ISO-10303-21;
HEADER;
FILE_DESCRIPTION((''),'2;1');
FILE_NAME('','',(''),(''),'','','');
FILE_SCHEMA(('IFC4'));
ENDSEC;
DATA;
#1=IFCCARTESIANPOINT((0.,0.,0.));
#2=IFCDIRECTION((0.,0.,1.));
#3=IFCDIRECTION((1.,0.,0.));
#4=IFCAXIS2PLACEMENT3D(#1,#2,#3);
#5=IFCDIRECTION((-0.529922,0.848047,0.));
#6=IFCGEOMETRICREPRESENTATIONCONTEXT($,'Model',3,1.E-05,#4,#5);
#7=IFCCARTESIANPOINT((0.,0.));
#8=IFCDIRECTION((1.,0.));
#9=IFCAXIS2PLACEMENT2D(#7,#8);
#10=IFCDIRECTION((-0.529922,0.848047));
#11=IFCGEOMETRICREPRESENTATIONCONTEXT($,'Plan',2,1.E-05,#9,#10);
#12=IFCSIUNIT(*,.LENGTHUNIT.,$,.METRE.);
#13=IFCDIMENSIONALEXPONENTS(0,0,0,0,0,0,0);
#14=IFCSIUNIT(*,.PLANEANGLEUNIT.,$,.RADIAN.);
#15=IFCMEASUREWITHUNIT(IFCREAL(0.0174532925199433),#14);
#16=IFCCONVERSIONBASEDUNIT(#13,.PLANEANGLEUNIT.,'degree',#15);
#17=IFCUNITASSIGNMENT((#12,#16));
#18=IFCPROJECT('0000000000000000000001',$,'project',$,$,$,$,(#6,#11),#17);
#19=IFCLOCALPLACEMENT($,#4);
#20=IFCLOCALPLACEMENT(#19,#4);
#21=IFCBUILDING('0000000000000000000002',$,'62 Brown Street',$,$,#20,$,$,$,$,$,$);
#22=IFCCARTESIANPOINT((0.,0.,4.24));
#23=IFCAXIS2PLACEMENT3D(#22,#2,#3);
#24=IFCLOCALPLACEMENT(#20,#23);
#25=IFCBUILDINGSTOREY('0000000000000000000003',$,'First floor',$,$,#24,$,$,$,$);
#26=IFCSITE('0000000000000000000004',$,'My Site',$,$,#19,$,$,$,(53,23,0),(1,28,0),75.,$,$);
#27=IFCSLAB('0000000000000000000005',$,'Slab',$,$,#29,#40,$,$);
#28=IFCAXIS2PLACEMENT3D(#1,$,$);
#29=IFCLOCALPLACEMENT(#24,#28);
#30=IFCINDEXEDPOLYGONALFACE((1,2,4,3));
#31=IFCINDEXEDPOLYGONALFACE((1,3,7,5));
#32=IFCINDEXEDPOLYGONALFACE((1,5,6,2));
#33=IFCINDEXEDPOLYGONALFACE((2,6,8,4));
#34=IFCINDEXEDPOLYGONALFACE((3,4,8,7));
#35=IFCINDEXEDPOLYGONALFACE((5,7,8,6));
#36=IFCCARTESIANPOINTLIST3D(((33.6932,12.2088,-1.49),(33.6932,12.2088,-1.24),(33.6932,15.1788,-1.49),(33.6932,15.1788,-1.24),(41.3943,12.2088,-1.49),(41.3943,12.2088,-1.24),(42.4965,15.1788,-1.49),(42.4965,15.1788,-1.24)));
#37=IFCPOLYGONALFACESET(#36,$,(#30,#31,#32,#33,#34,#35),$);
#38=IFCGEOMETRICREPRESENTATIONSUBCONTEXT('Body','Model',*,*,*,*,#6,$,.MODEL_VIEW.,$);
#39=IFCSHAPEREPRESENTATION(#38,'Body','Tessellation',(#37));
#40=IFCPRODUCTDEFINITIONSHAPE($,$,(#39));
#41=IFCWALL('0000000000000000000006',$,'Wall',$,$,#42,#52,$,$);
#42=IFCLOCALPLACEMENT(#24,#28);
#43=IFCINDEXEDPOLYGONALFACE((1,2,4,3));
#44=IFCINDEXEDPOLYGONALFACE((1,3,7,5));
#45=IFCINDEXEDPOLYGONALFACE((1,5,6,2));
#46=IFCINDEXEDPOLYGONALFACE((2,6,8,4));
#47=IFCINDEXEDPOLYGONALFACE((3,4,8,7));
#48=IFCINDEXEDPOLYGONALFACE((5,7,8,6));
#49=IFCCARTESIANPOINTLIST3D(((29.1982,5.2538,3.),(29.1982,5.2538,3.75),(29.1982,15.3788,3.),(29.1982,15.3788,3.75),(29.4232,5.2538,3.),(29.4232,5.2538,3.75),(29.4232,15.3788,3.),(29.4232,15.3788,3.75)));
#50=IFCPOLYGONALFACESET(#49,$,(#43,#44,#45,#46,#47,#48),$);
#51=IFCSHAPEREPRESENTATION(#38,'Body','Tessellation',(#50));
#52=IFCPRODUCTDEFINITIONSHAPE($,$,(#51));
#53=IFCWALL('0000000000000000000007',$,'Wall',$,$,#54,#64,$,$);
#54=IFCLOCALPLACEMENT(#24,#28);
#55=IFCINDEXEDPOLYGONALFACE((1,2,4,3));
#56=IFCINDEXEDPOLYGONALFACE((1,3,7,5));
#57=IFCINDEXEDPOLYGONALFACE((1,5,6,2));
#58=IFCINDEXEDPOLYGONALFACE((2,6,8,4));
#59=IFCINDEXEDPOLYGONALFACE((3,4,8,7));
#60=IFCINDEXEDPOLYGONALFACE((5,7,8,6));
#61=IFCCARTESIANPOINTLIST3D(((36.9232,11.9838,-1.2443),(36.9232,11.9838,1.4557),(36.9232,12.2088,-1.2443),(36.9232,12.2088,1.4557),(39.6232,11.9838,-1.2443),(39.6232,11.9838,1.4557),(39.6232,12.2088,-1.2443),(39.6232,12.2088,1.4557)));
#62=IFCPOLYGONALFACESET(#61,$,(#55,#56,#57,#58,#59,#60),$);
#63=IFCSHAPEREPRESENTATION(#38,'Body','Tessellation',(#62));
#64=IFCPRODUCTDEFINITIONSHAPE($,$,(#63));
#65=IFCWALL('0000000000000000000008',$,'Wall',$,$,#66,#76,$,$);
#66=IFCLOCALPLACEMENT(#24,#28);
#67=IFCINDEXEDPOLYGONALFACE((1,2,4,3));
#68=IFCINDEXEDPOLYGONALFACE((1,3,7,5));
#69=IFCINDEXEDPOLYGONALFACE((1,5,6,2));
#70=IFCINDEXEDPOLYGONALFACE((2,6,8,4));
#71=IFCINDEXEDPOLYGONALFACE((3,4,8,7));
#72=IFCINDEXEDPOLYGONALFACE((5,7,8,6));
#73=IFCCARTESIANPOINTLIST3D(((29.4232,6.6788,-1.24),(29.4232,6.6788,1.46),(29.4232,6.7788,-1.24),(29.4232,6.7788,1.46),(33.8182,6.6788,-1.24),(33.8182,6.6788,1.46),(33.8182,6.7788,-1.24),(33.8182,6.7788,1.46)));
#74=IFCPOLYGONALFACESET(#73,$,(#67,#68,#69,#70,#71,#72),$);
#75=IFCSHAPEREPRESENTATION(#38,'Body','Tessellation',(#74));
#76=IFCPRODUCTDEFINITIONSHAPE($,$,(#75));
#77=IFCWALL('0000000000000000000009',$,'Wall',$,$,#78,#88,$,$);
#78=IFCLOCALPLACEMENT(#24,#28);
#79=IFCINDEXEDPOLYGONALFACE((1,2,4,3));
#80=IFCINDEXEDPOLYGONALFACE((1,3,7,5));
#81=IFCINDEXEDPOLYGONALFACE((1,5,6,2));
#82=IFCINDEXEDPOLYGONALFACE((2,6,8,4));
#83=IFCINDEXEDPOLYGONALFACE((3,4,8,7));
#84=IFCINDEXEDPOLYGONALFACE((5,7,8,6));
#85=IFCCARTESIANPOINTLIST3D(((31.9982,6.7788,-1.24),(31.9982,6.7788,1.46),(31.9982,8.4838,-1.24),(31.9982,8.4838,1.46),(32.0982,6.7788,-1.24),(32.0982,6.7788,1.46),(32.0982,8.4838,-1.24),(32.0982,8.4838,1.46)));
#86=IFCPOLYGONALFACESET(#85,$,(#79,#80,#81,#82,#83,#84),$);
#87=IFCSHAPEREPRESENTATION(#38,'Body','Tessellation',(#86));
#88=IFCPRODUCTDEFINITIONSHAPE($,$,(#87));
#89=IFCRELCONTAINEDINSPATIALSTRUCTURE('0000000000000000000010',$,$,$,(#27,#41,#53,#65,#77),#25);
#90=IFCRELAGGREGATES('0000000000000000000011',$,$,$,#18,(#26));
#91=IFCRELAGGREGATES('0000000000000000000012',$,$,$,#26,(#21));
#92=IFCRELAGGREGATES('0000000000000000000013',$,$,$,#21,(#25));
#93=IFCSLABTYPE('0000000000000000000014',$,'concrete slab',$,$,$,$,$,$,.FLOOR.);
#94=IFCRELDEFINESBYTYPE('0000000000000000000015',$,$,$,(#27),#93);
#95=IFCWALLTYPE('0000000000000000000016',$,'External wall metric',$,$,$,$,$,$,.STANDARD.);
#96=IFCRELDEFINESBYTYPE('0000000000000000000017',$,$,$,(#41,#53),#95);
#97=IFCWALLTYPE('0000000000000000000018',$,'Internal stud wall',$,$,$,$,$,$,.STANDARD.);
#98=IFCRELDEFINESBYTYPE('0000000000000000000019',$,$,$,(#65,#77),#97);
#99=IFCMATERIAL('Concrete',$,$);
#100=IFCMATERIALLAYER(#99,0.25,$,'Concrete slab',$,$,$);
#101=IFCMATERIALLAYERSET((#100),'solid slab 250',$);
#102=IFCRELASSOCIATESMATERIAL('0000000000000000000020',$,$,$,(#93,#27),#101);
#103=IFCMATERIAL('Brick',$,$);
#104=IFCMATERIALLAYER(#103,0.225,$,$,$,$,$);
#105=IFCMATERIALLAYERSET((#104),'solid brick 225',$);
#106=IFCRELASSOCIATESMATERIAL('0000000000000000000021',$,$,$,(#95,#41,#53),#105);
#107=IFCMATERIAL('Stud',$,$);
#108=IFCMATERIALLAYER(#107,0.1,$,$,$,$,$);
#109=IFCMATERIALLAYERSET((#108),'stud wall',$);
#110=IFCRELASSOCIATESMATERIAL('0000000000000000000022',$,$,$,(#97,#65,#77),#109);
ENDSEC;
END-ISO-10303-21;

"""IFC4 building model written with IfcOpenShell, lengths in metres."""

from ifc_helpers import new_model, entity, si_unit, converted_unit, direction, frame, origin_with_axes, origin_2d_with_axis, place, context, subcontext, project, spatial, line, indexed_curve, outline, extrude, material, layer, layer_set, layer_usage, type_object, element, save


model = new_model("IFC4")

# Units and contexts
model_context = context("Model", 3, precision=1e-05, world=origin_with_axes(), true_north=direction((-0.529922, 0.848047, 0.0)))
plan_context = context("Plan", 2, precision=1e-05, world=origin_2d_with_axis(), true_north=direction((-0.529922, 0.848047)))
body_context_1 = subcontext(model_context, "Body", "Model", "MODEL_VIEW")
ifc_project = project(units=[si_unit("LENGTHUNIT", "METRE"), converted_unit("PLANEANGLEUNIT", "degree", entity("IfcReal", 0.0174532925199433), si_unit("PLANEANGLEUNIT", "RADIAN"), dimensions=[0, 0, 0, 0, 0, 0, 0])], contexts=[model_context, plan_context])

# Site, building, storey
site_placement = place(None, origin_with_axes())
site = spatial("IfcSite", under=ifc_project, at=site_placement, Name="My Site", RefLatitude=(53, 23, 0), RefLongitude=(1, 28, 0), RefElevation=75.0)
building_placement = place(site_placement, origin_with_axes())
building = spatial("IfcBuilding", under=site, at=building_placement, Name="62 Brown Street")
storey_placement = place(building_placement, frame((0.0, 0.0, 4.24), z_axis=(0.0, 0.0, 1.0), x_axis=(1.0, 0.0, 0.0)))
storey = spatial("IfcBuildingStorey", under=building, at=storey_placement, Name="First floor")

# Slab
ifc_material_1 = material(Name="Concrete")
ifc_layer_1 = layer(ifc_material_1, 0.25, Name="Concrete slab")
ifc_layer_set_1 = layer_set([ifc_layer_1], Name="solid slab 250")
ifc_layer_usage_1 = layer_usage(ifc_layer_set_1, "AXIS3", "POSITIVE", 0.0)
slab_type = type_object("IfcSlabType", Name="concrete slab", PredefinedType="FLOOR", material=ifc_layer_set_1)
slab_placement = place(storey_placement, frame((33.6932, 12.2088, -1.49), z_axis=(0.0, 0.0, 1.0), x_axis=(1.0, 0.0, 0.0)))
element("IfcSlab", 1, at=slab_placement, inside=storey, type_object=slab_type, material=ifc_layer_usage_1, Name="Slab", context=body_context_1, shape_type="SweptSolid", body=[
    extrude(outline(indexed_curve([(8.8033, 2.97), (7.7011, 0.0), (0.0, 0.0), (0.0, 2.97)], segments=[line(4, 1), line(1, 2), line(2, 3), line(3, 4)], self_intersect=False)), None, (0.0, 0.0, 1.0), 0.25),
])

# Shared definitions
ifc_material_2 = material(Name="Brick")
ifc_layer_2 = layer(ifc_material_2, 0.225)
ifc_layer_set_2 = layer_set([ifc_layer_2], Name="solid brick 225")
wall_type_1 = type_object("IfcWallType", Name="External wall metric", PredefinedType="STANDARD", material=ifc_layer_set_2)

# Walls
ifc_layer_usage_2 = layer_usage(ifc_layer_set_2, "AXIS2", "POSITIVE", 0.0)
wall_1_placement = place(storey_placement, frame((29.4232, 5.2538, 3.0), z_axis=(0.0, 0.0, 1.0), x_axis=(0.0, 1.0, 0.0)))
element("IfcWall", 2, at=wall_1_placement, inside=storey, type_object=wall_type_1, material=ifc_layer_usage_2, Name="Wall", context=body_context_1, shape_type="SweptSolid", body=[
    extrude(outline(indexed_curve([(0.0, 0.0), (0.0, 0.225), (10.125, 0.225), (10.125, 0.0), (0.0, 0.0)], self_intersect=False)), origin_with_axes(), (0.0, 0.0, 1.0), 0.75),
])
ifc_layer_usage_3 = layer_usage(ifc_layer_set_2, "AXIS2", "POSITIVE", 0.0)
wall_2_placement = place(storey_placement, frame((36.9232, 11.9838, -1.2443), z_axis=(0.0, 0.0, 1.0), x_axis=(1.0, 0.0, 0.0)))
element("IfcWall", 3, at=wall_2_placement, inside=storey, type_object=wall_type_1, material=ifc_layer_usage_3, Name="Wall", context=body_context_1, shape_type="SweptSolid", body=[
    extrude(outline(indexed_curve([(0.0, 0.0), (0.0, 0.225), (2.7, 0.225), (2.7, 0.0), (0.0, 0.0)], self_intersect=False)), origin_with_axes(), (0.0, 0.0, 1.0), 2.7),
])

# Shared definitions
ifc_material_3 = material(Name="Stud")
ifc_layer_3 = layer(ifc_material_3, 0.1)
ifc_layer_set_3 = layer_set([ifc_layer_3], Name="stud wall")
wall_type_2 = type_object("IfcWallType", Name="Internal stud wall", PredefinedType="STANDARD", material=ifc_layer_set_3)

# Walls
ifc_layer_usage_4 = layer_usage(ifc_layer_set_3, "AXIS2", "POSITIVE", 0.0)
wall_3_placement = place(storey_placement, frame((33.8182, 6.7788, -1.24), z_axis=(0.0, 0.0, 1.0), x_axis=(-1.0, 0.000001, 0.0)))
element("IfcWall", 4, at=wall_3_placement, inside=storey, type_object=wall_type_2, material=ifc_layer_usage_4, Name="Wall", context=body_context_1, shape_type="SweptSolid", body=[
    extrude(outline(indexed_curve([(0.0, 0.0), (0.0, 0.1), (4.395, 0.1), (4.395, 0.0), (0.0, 0.0)], self_intersect=False)), origin_with_axes(), (0.0, 0.0, 1.0), 2.7),
])
ifc_layer_usage_5 = layer_usage(ifc_layer_set_3, "AXIS2", "POSITIVE", 0.0)
wall_4_placement = place(storey_placement, frame((32.0982, 6.7788, -1.24), z_axis=(0.0, 0.0, 1.0), x_axis=(0.000001, 1.0, 0.0)))
element("IfcWall", 5, at=wall_4_placement, inside=storey, type_object=wall_type_2, material=ifc_layer_usage_5, Name="Wall", context=body_context_1, shape_type="SweptSolid", body=[
    extrude(outline(indexed_curve([(0.0, 0.0), (0.0, 0.1), (1.705, 0.1), (1.705, 0.0), (0.0, 0.0)], self_intersect=False)), origin_with_axes(), (0.0, 0.0, 1.0), 2.7),
])

save(model, "model.ifc")
